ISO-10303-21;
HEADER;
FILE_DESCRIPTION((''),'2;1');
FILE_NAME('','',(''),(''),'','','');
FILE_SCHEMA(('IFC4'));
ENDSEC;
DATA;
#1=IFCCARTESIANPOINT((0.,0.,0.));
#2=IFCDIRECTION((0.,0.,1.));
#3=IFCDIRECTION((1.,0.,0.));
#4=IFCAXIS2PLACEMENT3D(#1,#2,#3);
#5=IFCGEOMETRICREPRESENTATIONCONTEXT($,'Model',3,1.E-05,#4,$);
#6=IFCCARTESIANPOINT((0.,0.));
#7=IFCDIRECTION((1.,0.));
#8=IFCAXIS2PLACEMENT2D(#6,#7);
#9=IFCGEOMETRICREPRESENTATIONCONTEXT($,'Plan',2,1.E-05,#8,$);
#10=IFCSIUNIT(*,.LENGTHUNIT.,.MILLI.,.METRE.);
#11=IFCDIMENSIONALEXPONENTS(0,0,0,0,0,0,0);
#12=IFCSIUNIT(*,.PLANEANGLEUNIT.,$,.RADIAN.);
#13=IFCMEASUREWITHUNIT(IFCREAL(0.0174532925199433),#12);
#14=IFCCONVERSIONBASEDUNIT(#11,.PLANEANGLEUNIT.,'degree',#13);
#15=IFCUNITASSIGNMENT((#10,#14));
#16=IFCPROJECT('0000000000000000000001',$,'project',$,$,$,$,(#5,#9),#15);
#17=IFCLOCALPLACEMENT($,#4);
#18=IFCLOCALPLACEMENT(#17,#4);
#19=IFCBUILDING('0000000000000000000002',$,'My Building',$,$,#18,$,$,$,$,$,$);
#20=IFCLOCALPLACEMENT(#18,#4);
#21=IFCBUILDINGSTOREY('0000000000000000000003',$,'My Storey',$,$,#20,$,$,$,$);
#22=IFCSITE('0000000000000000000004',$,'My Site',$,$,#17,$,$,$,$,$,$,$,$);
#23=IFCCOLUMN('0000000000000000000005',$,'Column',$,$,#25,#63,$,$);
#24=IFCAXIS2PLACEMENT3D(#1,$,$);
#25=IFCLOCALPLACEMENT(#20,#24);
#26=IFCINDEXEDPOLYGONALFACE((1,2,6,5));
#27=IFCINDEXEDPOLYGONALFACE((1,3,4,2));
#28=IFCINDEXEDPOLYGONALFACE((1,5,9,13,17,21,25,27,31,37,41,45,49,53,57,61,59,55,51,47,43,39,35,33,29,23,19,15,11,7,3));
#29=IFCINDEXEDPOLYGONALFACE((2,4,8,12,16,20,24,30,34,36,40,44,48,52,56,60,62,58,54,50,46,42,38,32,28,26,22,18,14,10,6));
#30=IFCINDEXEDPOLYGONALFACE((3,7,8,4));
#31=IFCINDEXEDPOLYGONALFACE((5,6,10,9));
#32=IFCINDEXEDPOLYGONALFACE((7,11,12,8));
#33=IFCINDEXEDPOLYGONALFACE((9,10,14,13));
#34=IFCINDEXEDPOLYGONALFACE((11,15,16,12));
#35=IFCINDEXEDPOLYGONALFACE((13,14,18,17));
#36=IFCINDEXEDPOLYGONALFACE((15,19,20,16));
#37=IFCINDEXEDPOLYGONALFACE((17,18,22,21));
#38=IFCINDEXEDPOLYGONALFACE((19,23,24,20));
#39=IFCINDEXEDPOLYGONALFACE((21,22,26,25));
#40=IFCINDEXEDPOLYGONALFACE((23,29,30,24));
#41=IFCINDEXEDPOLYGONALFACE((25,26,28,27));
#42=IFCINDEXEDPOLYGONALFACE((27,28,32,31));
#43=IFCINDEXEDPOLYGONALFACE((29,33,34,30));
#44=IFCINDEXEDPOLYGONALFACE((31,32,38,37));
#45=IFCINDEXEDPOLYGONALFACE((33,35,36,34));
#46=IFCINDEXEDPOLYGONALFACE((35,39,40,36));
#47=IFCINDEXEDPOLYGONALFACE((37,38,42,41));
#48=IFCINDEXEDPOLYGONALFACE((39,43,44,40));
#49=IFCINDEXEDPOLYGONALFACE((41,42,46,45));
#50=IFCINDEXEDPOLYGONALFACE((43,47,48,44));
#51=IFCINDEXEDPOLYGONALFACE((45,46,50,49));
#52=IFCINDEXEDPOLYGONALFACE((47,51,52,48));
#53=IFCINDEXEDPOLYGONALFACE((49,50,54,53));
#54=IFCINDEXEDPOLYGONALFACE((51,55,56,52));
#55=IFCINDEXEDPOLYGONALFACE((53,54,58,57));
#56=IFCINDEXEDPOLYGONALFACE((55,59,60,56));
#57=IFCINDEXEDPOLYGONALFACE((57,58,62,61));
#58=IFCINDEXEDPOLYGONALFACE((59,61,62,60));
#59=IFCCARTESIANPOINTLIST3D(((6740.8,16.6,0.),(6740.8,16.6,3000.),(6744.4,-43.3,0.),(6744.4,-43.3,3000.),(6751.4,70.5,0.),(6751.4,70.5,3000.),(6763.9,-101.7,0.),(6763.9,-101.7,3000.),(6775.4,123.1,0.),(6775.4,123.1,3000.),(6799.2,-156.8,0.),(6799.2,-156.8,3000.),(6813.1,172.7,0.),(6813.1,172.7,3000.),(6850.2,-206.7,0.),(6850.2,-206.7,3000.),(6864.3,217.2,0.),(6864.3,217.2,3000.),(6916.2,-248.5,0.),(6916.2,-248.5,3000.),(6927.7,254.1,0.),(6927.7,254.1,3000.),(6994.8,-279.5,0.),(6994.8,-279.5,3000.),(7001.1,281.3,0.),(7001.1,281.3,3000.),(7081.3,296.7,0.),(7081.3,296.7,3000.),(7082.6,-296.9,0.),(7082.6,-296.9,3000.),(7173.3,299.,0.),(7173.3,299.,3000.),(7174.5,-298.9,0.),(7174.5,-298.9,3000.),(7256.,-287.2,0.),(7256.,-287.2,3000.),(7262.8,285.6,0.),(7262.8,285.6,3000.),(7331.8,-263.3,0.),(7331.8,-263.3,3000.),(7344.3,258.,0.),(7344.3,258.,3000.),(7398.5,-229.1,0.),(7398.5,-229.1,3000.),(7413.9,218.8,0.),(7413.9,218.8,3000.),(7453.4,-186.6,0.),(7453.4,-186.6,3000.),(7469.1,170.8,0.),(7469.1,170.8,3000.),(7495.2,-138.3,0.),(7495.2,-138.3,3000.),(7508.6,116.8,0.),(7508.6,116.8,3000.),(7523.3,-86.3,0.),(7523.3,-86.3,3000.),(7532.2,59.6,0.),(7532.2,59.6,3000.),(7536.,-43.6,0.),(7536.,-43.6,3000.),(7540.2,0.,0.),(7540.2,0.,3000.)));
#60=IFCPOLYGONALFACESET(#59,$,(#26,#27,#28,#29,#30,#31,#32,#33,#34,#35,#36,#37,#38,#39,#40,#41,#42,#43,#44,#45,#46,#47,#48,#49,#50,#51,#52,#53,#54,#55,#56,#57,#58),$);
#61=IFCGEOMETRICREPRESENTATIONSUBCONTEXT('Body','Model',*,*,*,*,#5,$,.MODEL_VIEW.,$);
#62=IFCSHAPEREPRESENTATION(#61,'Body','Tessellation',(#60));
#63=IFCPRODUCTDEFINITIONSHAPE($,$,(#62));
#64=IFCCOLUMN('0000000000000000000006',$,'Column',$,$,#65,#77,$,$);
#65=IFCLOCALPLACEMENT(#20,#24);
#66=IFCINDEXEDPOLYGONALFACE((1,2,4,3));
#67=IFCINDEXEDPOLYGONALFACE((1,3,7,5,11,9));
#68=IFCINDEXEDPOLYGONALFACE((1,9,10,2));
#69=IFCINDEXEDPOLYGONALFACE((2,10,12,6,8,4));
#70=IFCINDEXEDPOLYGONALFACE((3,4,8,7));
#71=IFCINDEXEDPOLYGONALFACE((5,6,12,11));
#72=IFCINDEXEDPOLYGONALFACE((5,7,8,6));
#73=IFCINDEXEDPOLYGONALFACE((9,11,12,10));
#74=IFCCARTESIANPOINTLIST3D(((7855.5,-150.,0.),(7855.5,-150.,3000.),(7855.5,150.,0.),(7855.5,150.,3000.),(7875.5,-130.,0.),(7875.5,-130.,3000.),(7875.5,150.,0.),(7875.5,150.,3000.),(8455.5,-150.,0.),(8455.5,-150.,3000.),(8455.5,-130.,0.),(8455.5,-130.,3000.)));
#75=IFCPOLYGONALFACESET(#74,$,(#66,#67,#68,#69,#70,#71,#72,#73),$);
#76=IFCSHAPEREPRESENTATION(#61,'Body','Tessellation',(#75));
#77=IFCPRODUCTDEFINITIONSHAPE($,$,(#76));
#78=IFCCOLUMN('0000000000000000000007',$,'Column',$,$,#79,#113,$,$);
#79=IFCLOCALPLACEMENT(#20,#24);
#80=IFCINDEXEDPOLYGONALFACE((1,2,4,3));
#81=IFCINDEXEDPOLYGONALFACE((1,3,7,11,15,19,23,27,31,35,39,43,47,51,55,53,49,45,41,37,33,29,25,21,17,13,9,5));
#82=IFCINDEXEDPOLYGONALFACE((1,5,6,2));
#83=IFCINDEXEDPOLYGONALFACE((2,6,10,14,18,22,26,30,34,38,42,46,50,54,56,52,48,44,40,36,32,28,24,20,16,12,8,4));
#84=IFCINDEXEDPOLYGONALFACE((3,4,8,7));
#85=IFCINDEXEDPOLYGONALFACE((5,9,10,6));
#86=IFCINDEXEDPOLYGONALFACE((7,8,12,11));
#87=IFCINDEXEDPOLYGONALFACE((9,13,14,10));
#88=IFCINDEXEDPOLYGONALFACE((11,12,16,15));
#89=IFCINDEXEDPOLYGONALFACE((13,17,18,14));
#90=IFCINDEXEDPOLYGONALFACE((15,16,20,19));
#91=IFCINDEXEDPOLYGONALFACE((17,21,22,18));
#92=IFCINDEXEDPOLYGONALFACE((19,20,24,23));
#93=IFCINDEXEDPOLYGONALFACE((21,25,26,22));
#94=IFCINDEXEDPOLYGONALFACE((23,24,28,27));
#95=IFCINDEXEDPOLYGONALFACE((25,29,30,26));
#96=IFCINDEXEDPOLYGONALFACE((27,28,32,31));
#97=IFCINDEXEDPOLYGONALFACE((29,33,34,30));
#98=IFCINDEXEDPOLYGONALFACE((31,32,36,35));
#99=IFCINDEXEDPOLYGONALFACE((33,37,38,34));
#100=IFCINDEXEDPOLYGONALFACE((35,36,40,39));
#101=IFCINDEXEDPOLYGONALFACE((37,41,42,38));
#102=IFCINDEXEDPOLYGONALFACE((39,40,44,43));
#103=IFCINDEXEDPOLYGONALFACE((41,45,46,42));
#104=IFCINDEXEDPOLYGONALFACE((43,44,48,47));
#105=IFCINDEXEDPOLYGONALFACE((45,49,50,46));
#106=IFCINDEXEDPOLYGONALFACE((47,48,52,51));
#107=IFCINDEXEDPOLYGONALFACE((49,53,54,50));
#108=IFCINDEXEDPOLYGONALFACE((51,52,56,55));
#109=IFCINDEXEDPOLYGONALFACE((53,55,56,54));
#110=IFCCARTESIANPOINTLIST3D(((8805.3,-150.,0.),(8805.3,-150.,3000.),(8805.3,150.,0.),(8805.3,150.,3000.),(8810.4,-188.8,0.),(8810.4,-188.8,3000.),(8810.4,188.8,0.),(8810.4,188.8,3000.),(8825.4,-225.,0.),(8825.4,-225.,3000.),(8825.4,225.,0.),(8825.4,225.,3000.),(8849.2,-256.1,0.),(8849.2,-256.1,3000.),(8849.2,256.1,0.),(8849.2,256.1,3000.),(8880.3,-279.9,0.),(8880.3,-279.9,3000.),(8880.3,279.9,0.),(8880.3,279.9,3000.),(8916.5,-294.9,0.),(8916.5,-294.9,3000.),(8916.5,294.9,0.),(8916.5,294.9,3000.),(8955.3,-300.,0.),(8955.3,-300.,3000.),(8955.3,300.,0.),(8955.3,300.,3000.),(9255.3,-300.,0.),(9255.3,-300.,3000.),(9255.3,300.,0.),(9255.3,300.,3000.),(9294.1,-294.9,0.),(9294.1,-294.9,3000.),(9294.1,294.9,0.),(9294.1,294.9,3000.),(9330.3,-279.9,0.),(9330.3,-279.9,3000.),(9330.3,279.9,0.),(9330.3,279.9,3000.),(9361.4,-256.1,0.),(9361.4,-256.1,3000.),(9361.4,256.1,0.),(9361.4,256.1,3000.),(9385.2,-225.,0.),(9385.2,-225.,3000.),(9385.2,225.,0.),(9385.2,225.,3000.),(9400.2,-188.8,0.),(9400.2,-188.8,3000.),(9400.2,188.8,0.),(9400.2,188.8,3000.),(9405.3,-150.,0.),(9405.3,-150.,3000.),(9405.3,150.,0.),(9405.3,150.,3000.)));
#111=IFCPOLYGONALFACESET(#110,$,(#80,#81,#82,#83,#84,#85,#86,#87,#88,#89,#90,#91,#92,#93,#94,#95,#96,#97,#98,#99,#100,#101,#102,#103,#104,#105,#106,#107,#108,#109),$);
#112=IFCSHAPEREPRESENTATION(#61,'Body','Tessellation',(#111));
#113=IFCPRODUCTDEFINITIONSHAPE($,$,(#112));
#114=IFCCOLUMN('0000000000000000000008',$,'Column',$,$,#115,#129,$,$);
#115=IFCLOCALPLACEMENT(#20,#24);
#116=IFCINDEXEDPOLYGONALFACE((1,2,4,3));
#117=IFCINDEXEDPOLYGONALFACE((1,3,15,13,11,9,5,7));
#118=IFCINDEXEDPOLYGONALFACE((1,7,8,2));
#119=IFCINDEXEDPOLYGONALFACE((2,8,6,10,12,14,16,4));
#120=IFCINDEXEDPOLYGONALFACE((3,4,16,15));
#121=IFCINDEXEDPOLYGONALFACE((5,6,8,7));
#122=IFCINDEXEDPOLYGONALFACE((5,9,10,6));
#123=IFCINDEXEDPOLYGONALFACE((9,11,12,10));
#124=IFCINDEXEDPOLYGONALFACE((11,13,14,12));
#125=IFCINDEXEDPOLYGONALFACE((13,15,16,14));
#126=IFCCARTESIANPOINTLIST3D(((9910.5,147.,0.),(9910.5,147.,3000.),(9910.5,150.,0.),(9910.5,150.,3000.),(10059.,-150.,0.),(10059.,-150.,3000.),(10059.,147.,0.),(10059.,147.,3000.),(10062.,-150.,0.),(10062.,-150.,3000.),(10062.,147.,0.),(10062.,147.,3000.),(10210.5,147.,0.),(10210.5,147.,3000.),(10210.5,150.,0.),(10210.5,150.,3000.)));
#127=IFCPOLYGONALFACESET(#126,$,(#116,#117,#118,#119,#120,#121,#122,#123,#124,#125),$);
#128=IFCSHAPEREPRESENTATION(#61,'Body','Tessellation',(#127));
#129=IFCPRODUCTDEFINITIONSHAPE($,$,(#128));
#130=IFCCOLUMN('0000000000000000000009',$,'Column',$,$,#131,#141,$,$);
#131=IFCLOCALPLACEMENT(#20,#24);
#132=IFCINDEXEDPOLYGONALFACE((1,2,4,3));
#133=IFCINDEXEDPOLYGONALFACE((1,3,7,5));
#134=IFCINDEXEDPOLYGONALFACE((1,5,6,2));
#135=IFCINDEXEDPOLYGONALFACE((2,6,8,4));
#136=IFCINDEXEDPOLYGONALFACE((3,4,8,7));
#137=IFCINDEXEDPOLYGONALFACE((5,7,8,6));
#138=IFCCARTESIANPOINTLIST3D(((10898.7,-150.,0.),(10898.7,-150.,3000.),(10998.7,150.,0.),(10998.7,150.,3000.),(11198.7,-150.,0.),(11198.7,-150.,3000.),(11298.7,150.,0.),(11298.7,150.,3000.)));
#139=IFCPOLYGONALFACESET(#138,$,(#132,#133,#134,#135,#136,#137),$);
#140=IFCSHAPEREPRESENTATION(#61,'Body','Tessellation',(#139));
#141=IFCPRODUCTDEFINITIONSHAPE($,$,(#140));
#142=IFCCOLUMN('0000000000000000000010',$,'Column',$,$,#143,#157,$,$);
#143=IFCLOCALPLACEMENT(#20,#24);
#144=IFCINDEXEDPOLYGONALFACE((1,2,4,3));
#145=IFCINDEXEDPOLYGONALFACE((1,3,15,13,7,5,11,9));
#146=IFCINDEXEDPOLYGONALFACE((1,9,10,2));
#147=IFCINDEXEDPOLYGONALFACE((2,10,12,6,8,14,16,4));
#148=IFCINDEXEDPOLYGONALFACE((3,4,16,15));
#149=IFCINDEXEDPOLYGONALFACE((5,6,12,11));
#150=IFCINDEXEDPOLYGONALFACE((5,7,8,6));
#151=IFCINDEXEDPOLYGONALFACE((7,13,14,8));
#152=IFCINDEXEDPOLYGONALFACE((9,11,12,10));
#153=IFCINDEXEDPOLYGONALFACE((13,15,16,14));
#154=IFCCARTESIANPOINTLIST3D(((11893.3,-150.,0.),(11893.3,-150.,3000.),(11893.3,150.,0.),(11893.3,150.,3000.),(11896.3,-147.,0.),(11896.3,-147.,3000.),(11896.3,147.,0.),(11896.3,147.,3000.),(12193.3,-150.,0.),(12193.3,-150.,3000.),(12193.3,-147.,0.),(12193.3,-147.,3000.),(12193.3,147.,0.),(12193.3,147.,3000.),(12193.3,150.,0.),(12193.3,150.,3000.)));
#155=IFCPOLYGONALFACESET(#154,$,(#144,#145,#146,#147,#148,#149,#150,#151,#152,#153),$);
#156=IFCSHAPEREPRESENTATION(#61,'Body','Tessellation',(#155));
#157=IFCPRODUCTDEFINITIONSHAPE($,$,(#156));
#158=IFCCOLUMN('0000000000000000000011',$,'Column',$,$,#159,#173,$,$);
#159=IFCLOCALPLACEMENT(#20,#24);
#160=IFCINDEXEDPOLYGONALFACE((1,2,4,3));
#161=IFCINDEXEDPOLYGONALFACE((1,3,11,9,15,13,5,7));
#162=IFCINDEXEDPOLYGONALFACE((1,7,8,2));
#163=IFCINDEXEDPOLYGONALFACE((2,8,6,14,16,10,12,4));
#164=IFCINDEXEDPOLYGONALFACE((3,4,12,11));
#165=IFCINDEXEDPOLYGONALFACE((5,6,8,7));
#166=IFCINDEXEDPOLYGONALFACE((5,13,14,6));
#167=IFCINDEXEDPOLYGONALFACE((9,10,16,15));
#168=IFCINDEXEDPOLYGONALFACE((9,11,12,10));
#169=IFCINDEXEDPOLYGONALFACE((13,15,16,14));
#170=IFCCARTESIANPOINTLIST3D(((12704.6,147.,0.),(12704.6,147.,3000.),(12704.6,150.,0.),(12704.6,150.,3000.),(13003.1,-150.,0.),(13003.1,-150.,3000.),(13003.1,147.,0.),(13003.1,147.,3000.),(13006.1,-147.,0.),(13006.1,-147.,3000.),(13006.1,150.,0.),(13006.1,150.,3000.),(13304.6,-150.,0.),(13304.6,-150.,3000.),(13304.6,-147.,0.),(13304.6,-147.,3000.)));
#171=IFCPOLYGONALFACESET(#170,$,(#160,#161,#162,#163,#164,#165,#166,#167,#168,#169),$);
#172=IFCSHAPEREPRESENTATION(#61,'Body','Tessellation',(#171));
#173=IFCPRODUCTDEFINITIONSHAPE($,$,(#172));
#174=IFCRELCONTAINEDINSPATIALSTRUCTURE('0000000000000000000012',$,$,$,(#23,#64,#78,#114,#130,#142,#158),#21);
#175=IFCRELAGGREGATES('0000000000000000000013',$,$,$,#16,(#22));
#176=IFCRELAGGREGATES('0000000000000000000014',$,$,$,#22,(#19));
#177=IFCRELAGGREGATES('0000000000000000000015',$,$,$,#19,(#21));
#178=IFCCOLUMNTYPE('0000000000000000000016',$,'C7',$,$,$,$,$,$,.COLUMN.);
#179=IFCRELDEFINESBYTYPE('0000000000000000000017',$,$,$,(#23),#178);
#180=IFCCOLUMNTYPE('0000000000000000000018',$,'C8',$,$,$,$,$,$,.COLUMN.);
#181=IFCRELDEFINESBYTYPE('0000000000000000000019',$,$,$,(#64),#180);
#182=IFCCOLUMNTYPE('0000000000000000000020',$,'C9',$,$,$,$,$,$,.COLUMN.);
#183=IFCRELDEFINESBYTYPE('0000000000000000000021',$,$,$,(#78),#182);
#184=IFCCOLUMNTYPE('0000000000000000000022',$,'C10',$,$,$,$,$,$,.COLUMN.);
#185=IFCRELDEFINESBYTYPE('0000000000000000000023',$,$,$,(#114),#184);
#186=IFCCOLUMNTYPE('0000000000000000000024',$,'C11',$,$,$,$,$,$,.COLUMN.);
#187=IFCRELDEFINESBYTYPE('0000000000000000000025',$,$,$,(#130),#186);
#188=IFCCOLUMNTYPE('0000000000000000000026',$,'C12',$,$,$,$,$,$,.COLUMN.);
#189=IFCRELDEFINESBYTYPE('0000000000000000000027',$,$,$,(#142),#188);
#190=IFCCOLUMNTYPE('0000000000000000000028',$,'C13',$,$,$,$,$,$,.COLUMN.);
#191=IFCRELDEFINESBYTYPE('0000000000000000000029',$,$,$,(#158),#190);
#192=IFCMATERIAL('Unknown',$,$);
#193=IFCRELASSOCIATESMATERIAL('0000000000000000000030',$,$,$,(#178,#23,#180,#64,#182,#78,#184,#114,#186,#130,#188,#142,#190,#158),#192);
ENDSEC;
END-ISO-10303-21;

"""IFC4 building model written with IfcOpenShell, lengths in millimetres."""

from ifc_helpers import new_model, entity, si_unit, converted_unit, frame, origin_with_axes, origin_2d_with_axis, place, context, subcontext, project, spatial, rounded_rectangle, ellipse, l_section, t_section, u_section, z_section, extrude, material, material_profile, profile_set, profile_usage, type_object, element, save


model = new_model("IFC4")

# Units and contexts
model_context = context("Model", 3, precision=1e-05, world=origin_with_axes())
plan_context = context("Plan", 2, precision=1e-05, world=origin_2d_with_axis())
body_context = subcontext(model_context, "Body", "Model", "MODEL_VIEW")
ifc_project = project(units=[si_unit("LENGTHUNIT", "METRE", prefix="MILLI"), converted_unit("PLANEANGLEUNIT", "degree", entity("IfcReal", 0.0174532925199433), si_unit("PLANEANGLEUNIT", "RADIAN"), dimensions=[0, 0, 0, 0, 0, 0, 0])], contexts=[model_context, plan_context])

# Site, building, storey
site_placement = place(None, origin_with_axes())
site = spatial("IfcSite", under=ifc_project, at=site_placement, Name="My Site")
building_placement = place(site_placement, origin_with_axes())
building = spatial("IfcBuilding", under=site, at=building_placement, Name="My Building")
storey_placement = place(building_placement, origin_with_axes())
storey = spatial("IfcBuildingStorey", under=building, at=storey_placement, Name="My Storey")

# Columns
ifc_material = material(Name="Unknown")
ifc_material_profile_1 = material_profile(ifc_material, ellipse(SemiAxis1=400.0, SemiAxis2=300.0))
ifc_profile_set_1 = profile_set([ifc_material_profile_1])
ifc_profile_usage_1 = profile_usage(ifc_profile_set_1)
column_type_1 = type_object("IfcColumnType", Name="C7", PredefinedType="COLUMN", material=ifc_profile_set_1)
column_1_placement = place(storey_placement, frame((7140.2, 0.0, 0.0), z_axis=(0.0, 0.0, 1.0), x_axis=(1.0, 0.0, 0.0)))
element("IfcColumn", 1, at=column_1_placement, inside=storey, type_object=column_type_1, material=ifc_profile_usage_1, Name="Column", context=body_context, shape_type="SweptSolid", body=[
    extrude(ellipse(SemiAxis1=400.0, SemiAxis2=300.0), origin_with_axes(), (0.0, 0.0, 1.0), 3000.0),
])
ifc_material_profile_2 = material_profile(ifc_material, l_section(Depth=300.0, Width=600.0, Thickness=20.0, FilletRadius=0.0, EdgeRadius=0.0, LegSlope=0.0))
ifc_profile_set_2 = profile_set([ifc_material_profile_2])
ifc_profile_usage_2 = profile_usage(ifc_profile_set_2)
column_type_2 = type_object("IfcColumnType", Name="C8", PredefinedType="COLUMN", material=ifc_profile_set_2)
column_2_placement = place(storey_placement, frame((8155.5, 0.0, 0.0), z_axis=(0.0, 0.0, 1.0), x_axis=(1.0, 0.0, 0.0)))
element("IfcColumn", 2, at=column_2_placement, inside=storey, type_object=column_type_2, material=ifc_profile_usage_2, Name="Column", context=body_context, shape_type="SweptSolid", body=[
    extrude(l_section(Depth=300.0, Width=600.0, Thickness=20.0, FilletRadius=0.0, EdgeRadius=0.0, LegSlope=0.0), origin_with_axes(), (0.0, 0.0, 1.0), 3000.0),
])
ifc_material_profile_3 = material_profile(ifc_material, rounded_rectangle(XDim=600.0, YDim=600.0, RoundingRadius=150.0))
ifc_profile_set_3 = profile_set([ifc_material_profile_3])
ifc_profile_usage_3 = profile_usage(ifc_profile_set_3)
column_type_3 = type_object("IfcColumnType", Name="C9", PredefinedType="COLUMN", material=ifc_profile_set_3)
column_3_placement = place(storey_placement, frame((9105.3, 0.0, 0.0), z_axis=(0.0, 0.0, 1.0), x_axis=(1.0, 0.0, 0.0)))
element("IfcColumn", 3, at=column_3_placement, inside=storey, type_object=column_type_3, material=ifc_profile_usage_3, Name="Column", context=body_context, shape_type="SweptSolid", body=[
    extrude(rounded_rectangle(XDim=600.0, YDim=600.0, RoundingRadius=150.0), origin_with_axes(), (0.0, 0.0, 1.0), 3000.0),
])
ifc_material_profile_4 = material_profile(ifc_material, t_section(Depth=300.0, FlangeWidth=300.0, WebThickness=3.0, FlangeThickness=3.0))
ifc_profile_set_4 = profile_set([ifc_material_profile_4])
ifc_profile_usage_4 = profile_usage(ifc_profile_set_4)
column_type_4 = type_object("IfcColumnType", Name="C10", PredefinedType="COLUMN", material=ifc_profile_set_4)
column_4_placement = place(storey_placement, frame((10060.5, 0.0, 0.0), z_axis=(0.0, 0.0, 1.0), x_axis=(1.0, 0.0, 0.0)))
element("IfcColumn", 4, at=column_4_placement, inside=storey, type_object=column_type_4, material=ifc_profile_usage_4, Name="Column", context=body_context, shape_type="SweptSolid", body=[
    extrude(t_section(Depth=300.0, FlangeWidth=300.0, WebThickness=3.0, FlangeThickness=3.0), origin_with_axes(), (0.0, 0.0, 1.0), 3000.0),
])
ifc_material_profile_5 = material_profile(ifc_material, entity("IfcTrapeziumProfileDef", "AREA", None, None, 300.0, 300.0, 300.0, 100.0))
ifc_profile_set_5 = profile_set([ifc_material_profile_5])
ifc_profile_usage_5 = profile_usage(ifc_profile_set_5)
column_type_5 = type_object("IfcColumnType", Name="C11", PredefinedType="COLUMN", material=ifc_profile_set_5)
column_5_placement = place(storey_placement, frame((11098.7, 0.0, 0.0), z_axis=(0.0, 0.0, 1.0), x_axis=(1.0, 0.0, 0.0)))
element("IfcColumn", 5, at=column_5_placement, inside=storey, type_object=column_type_5, material=ifc_profile_usage_5, Name="Column", context=body_context, shape_type="SweptSolid", body=[
    extrude(entity("IfcTrapeziumProfileDef", "AREA", None, None, 300.0, 300.0, 300.0, 100.0), origin_with_axes(), (0.0, 0.0, 1.0), 3000.0),
])
ifc_material_profile_6 = material_profile(ifc_material, u_section(Depth=300.0, FlangeWidth=300.0, WebThickness=3.0, FlangeThickness=3.0))
ifc_profile_set_6 = profile_set([ifc_material_profile_6])
ifc_profile_usage_6 = profile_usage(ifc_profile_set_6)
column_type_6 = type_object("IfcColumnType", Name="C12", PredefinedType="COLUMN", material=ifc_profile_set_6)
column_6_placement = place(storey_placement, frame((12043.3, 0.0, 0.0), z_axis=(0.0, 0.0, 1.0), x_axis=(1.0, 0.0, 0.0)))
element("IfcColumn", 6, at=column_6_placement, inside=storey, type_object=column_type_6, material=ifc_profile_usage_6, Name="Column", context=body_context, shape_type="SweptSolid", body=[
    extrude(u_section(Depth=300.0, FlangeWidth=300.0, WebThickness=3.0, FlangeThickness=3.0), origin_with_axes(), (0.0, 0.0, 1.0), 3000.0),
])
ifc_material_profile_7 = material_profile(ifc_material, z_section(Depth=300.0, FlangeWidth=300.0, WebThickness=3.0, FlangeThickness=3.0))
ifc_profile_set_7 = profile_set([ifc_material_profile_7])
ifc_profile_usage_7 = profile_usage(ifc_profile_set_7)
column_type_7 = type_object("IfcColumnType", Name="C13", PredefinedType="COLUMN", material=ifc_profile_set_7)
column_7_placement = place(storey_placement, frame((13004.6, 0.0, 0.0), z_axis=(0.0, 0.0, 1.0), x_axis=(1.0, 0.0, 0.0)))
element("IfcColumn", 7, at=column_7_placement, inside=storey, type_object=column_type_7, material=ifc_profile_usage_7, Name="Column", context=body_context, shape_type="SweptSolid", body=[
    extrude(z_section(Depth=300.0, FlangeWidth=300.0, WebThickness=3.0, FlangeThickness=3.0), origin_with_axes(), (0.0, 0.0, 1.0), 3000.0),
])

save(model, "model.ifc")
